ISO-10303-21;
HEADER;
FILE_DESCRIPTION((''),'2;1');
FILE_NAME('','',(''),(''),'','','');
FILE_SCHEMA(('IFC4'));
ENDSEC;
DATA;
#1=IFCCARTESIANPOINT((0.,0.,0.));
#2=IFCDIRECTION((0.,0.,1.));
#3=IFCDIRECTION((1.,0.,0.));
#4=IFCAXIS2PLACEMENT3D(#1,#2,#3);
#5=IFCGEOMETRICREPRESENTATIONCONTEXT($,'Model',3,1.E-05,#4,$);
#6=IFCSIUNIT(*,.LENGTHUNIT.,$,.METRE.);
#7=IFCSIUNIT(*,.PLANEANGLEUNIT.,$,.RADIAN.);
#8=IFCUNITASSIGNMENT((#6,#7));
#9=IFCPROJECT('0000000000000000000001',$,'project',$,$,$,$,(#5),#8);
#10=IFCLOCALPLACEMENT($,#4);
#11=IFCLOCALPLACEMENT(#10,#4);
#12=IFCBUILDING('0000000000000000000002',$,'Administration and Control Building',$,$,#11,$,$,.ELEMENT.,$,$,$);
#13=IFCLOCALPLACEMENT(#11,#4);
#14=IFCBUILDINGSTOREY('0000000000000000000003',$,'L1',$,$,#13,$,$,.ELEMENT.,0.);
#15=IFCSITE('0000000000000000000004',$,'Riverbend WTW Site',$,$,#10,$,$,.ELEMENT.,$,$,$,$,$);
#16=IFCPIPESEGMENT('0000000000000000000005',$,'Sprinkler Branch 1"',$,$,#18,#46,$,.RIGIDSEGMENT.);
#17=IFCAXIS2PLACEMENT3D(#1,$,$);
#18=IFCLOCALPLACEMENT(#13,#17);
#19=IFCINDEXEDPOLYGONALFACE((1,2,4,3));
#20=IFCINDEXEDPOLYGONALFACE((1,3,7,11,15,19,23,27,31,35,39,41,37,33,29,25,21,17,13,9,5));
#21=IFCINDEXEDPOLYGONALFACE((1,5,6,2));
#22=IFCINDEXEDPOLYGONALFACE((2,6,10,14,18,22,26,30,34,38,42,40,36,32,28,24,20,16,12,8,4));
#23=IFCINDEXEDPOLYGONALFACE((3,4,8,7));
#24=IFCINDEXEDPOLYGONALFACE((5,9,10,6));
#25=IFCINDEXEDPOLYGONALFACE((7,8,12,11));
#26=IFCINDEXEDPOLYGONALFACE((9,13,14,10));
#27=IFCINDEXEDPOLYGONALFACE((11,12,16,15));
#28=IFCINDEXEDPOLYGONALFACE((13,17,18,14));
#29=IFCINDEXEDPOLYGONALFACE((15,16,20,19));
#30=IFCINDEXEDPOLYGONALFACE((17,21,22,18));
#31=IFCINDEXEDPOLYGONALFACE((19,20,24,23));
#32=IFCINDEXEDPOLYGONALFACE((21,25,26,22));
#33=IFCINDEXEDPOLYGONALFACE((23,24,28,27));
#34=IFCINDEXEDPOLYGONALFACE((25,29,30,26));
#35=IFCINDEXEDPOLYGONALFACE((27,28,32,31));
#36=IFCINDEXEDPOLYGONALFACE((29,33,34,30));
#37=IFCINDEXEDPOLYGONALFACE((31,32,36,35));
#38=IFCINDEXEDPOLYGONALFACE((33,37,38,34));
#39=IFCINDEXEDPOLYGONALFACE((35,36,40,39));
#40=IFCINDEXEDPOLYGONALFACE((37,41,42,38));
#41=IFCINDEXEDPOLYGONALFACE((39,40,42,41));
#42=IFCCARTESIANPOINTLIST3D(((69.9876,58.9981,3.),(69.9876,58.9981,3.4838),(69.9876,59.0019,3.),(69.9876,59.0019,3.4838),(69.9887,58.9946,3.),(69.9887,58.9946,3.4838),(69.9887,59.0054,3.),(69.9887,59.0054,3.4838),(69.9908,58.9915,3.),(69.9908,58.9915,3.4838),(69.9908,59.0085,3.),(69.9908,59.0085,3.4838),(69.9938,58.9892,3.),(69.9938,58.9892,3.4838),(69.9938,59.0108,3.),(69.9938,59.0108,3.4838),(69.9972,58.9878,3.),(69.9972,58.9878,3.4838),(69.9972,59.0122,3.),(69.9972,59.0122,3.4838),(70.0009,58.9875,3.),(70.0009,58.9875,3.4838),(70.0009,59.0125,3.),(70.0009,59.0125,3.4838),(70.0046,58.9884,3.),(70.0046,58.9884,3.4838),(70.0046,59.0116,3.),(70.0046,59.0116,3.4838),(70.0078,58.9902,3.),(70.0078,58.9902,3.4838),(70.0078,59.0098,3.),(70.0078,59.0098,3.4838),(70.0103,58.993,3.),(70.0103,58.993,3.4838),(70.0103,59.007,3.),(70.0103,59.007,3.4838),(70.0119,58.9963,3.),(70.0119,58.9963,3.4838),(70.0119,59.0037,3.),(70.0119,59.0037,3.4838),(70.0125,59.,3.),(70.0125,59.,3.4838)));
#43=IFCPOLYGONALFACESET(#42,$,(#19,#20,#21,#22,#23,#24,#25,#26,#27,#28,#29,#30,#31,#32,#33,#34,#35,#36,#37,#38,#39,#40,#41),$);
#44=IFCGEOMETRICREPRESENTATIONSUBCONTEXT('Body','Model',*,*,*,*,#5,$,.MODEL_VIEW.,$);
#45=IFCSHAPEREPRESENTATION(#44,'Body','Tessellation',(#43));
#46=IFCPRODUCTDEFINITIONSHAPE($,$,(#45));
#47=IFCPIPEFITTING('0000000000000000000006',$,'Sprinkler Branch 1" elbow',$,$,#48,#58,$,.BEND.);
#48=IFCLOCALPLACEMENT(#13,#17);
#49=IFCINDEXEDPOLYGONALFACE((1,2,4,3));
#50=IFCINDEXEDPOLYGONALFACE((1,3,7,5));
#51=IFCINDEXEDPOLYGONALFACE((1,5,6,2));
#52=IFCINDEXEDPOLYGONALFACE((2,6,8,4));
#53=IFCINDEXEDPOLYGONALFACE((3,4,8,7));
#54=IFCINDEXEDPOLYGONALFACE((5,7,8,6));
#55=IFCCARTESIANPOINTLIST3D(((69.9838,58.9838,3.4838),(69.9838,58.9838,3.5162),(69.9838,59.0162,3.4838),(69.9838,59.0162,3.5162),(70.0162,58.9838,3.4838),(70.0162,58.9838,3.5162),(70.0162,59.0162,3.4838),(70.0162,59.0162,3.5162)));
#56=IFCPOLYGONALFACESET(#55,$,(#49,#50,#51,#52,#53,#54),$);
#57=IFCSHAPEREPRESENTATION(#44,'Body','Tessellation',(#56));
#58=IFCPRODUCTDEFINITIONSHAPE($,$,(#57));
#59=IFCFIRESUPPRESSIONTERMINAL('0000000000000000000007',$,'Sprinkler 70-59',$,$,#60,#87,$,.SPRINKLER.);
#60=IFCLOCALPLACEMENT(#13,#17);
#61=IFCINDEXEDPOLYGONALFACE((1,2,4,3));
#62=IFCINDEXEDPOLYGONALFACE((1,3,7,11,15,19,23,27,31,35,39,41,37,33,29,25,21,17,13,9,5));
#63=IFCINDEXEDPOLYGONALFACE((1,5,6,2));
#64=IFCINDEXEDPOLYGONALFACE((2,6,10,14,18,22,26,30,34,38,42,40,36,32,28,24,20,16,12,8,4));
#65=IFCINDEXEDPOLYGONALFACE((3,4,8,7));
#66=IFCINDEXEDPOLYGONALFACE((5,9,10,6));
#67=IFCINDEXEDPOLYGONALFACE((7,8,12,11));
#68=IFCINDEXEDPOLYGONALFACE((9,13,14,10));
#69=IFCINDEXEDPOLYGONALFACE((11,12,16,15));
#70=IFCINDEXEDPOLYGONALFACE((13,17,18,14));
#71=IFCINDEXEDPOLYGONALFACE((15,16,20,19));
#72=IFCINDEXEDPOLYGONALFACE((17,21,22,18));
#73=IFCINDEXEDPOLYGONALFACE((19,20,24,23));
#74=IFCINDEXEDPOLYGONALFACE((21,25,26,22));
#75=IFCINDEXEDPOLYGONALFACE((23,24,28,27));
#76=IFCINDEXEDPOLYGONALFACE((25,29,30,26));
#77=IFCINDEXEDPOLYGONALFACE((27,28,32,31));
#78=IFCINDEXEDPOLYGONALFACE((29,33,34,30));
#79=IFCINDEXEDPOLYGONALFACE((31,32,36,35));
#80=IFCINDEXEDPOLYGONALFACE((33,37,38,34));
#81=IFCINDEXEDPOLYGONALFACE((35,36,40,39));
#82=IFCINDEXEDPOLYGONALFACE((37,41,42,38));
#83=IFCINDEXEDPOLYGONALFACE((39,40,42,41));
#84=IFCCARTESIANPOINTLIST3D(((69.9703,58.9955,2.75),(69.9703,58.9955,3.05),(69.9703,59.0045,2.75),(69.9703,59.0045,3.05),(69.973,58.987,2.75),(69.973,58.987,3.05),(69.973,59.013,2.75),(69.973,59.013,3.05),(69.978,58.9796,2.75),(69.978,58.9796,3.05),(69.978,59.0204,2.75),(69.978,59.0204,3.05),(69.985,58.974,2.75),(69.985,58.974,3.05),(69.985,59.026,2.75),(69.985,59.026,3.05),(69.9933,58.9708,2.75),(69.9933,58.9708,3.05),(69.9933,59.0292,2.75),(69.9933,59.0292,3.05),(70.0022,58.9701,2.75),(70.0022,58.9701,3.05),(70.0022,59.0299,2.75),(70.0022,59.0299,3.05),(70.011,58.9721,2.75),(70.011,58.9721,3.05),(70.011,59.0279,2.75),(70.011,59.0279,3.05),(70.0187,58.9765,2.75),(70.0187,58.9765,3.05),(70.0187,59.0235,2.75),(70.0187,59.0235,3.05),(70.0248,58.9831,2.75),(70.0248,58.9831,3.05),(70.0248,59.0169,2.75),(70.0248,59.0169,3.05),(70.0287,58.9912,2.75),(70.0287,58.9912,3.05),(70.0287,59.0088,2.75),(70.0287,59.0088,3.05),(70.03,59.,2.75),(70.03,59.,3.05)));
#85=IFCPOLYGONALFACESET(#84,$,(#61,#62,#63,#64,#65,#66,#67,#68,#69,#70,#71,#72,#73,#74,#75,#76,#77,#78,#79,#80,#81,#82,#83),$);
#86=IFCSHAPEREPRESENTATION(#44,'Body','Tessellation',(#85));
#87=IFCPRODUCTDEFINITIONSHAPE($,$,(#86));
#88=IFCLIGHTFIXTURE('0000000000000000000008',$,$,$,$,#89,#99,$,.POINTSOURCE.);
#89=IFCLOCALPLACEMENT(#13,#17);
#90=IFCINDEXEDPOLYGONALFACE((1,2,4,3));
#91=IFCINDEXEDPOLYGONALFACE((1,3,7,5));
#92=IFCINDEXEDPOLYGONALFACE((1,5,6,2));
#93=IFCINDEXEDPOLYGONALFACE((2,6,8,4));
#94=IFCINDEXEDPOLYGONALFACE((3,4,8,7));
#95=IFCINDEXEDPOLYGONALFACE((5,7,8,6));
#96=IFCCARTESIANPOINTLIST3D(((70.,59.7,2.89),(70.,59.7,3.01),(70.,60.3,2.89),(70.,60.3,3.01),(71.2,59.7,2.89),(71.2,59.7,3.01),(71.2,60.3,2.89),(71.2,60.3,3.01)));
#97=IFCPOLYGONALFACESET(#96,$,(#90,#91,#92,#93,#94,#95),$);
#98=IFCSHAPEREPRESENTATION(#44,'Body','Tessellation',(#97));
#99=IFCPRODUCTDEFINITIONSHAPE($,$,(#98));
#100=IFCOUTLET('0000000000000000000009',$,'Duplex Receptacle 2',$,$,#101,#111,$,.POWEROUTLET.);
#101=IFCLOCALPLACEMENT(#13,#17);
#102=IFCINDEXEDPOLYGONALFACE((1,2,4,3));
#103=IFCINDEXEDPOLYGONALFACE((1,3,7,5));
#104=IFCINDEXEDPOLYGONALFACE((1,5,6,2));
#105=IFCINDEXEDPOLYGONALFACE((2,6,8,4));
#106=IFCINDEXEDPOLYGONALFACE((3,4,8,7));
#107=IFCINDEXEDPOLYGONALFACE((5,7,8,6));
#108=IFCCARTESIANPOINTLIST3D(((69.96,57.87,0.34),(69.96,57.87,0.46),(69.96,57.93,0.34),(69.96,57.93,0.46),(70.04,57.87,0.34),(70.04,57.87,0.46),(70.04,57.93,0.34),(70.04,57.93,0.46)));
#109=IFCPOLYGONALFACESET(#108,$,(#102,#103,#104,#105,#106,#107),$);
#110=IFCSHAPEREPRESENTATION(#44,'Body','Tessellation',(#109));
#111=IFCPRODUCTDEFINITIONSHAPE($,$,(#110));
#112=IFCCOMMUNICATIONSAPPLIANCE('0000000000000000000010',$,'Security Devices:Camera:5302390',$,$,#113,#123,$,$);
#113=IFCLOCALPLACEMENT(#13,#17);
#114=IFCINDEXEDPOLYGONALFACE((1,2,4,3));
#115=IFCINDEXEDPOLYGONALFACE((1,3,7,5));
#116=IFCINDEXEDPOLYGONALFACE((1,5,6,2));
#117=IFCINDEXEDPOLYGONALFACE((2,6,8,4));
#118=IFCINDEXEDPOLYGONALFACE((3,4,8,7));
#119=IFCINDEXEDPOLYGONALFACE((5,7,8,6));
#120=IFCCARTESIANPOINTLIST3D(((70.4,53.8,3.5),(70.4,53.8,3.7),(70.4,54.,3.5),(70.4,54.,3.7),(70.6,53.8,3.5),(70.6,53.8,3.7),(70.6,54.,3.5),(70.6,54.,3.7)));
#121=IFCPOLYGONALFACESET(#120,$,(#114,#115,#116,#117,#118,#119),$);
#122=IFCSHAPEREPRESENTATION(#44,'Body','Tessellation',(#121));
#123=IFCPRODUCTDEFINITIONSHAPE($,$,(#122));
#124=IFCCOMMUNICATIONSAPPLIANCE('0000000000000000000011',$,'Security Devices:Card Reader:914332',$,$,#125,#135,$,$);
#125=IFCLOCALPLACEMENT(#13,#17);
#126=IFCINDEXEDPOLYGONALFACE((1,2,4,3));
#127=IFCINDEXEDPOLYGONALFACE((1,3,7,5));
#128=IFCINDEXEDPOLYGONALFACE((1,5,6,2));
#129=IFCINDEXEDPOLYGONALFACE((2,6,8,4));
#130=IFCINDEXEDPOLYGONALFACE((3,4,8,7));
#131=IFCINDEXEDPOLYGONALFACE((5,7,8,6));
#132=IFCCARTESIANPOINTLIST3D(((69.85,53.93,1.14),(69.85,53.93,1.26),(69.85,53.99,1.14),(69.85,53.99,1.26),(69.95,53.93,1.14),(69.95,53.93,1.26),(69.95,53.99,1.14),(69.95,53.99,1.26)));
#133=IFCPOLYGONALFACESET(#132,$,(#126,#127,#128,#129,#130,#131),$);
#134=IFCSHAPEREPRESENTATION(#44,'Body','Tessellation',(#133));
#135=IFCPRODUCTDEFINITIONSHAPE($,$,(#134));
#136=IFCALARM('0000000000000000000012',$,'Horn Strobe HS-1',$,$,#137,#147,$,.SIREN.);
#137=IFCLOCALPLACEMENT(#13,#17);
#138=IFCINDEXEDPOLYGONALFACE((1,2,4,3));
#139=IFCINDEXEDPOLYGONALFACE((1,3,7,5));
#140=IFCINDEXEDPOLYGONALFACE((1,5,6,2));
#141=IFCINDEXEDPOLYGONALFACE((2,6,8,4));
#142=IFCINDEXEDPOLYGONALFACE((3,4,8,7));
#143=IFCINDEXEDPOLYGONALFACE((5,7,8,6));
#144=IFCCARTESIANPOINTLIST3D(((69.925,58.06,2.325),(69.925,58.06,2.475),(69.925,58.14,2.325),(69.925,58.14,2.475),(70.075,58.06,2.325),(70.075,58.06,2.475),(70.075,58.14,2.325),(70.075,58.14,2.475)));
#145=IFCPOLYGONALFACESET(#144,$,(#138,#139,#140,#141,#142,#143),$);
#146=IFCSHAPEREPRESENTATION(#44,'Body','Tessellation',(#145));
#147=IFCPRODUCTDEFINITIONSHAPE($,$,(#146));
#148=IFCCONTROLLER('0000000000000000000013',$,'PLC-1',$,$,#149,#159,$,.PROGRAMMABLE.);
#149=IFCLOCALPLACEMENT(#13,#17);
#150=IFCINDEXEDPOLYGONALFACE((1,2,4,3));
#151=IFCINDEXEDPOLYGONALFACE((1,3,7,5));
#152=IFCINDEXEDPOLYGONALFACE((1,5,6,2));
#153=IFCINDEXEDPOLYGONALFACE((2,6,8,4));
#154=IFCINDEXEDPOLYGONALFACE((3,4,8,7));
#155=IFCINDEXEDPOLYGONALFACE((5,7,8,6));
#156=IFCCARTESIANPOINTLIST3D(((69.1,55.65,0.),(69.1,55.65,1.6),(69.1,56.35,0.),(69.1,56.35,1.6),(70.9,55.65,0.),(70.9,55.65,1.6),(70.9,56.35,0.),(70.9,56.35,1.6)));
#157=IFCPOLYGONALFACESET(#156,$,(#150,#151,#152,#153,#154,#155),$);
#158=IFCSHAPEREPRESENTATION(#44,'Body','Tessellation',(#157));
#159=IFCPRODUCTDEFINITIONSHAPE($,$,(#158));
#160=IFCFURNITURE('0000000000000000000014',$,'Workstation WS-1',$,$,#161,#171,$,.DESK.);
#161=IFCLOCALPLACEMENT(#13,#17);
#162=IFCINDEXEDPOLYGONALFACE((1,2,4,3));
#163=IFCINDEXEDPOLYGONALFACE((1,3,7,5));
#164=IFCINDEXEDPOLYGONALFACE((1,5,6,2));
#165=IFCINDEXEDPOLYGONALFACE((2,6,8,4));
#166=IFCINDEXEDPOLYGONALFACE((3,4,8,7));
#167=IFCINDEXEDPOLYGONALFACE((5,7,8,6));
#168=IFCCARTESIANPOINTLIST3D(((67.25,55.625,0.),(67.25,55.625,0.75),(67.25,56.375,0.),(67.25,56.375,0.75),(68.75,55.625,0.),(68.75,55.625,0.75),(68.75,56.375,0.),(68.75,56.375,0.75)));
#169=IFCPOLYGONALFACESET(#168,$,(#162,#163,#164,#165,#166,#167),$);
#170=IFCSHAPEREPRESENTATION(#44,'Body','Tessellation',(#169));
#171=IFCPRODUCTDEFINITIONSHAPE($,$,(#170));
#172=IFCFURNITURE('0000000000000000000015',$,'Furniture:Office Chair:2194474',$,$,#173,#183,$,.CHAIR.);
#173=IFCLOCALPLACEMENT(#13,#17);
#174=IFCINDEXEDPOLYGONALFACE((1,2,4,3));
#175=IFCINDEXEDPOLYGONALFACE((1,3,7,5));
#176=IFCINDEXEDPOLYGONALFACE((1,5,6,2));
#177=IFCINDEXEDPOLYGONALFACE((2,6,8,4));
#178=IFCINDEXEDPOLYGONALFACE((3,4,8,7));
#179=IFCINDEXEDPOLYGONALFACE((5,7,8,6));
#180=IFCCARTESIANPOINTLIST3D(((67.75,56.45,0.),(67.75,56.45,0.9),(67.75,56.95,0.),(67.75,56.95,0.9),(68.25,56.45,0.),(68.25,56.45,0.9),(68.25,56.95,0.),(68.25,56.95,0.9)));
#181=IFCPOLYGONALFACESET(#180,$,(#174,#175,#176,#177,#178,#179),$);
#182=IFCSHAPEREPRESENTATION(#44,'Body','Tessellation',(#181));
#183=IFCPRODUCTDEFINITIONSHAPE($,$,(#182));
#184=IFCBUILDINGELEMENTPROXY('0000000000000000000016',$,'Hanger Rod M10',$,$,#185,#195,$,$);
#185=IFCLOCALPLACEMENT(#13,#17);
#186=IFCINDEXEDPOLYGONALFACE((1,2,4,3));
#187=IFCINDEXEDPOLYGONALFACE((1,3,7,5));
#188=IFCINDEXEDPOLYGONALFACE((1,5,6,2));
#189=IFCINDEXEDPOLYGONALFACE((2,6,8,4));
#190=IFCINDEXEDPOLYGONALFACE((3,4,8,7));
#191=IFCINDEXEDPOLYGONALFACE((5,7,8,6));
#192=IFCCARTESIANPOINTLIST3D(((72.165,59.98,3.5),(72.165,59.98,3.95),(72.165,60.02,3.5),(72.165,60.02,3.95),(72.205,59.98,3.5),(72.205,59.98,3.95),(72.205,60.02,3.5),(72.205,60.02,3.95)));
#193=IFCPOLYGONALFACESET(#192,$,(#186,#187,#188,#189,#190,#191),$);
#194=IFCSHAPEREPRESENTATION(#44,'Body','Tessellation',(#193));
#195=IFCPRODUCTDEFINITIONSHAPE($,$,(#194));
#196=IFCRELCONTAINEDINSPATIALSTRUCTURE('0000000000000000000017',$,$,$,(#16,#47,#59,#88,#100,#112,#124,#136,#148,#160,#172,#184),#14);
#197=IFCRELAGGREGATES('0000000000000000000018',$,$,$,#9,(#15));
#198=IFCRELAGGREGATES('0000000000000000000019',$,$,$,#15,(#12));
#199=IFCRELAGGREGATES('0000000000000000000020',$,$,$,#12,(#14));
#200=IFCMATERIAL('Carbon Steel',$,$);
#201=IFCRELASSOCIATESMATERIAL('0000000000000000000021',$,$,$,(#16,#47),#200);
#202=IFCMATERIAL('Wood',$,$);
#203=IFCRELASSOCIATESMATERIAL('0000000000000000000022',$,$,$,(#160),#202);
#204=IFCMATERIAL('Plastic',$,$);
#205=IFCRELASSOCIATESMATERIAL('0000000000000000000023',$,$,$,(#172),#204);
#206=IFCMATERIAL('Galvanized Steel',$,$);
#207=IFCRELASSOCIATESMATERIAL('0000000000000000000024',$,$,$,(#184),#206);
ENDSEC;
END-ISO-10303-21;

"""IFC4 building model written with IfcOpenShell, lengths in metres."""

from ifc_helpers import new_model, si_unit, frame, origin_with_axes, origin_2d, place, context, subcontext, project, spatial, rectangle, circle, extrude, material, element, save


model = new_model("IFC4")

# Units and contexts
model_context = context("Model", 3, precision=1e-05, world=origin_with_axes())
body_context = subcontext(model_context, "Body", "Model", "MODEL_VIEW")
ifc_project = project(units=[si_unit("LENGTHUNIT", "METRE"), si_unit("PLANEANGLEUNIT", "RADIAN")], contexts=[model_context])

# Site, building, storey
site_placement = place(None, origin_with_axes())
site = spatial("IfcSite", under=ifc_project, at=site_placement, Name="Riverbend WTW Site", CompositionType="ELEMENT")
building_placement = place(site_placement, origin_with_axes())
building = spatial("IfcBuilding", under=site, at=building_placement, Name="Administration and Control Building", CompositionType="ELEMENT")
storey_placement = place(building_placement, origin_with_axes())
storey = spatial("IfcBuildingStorey", under=building, at=storey_placement, Name="L1", CompositionType="ELEMENT", Elevation=0.0)

# Shared definitions
ifc_material_1 = material(Name="Galvanized Steel")

# Pipe segment
ifc_material_2 = material(Name="Carbon Steel")
pipe_segment_placement = place(None, frame((70.0, 59.0, 3.4838), z_axis=(0.0, 0.0, 1.0), x_axis=(1.0, 0.0, 0.0)))
element("IfcPipeSegment", 1, at=pipe_segment_placement, inside=storey, material=ifc_material_2, Name="Sprinkler Branch 1\"", PredefinedType="RIGIDSEGMENT", context=body_context, shape_type="SweptSolid", body=[
    extrude(circle(Radius=0.0125, at=origin_2d()), frame((0.0, 0.0, 0.0), z_axis=(0.0, 0.0, -1.0), x_axis=(1.0, 0.0, 0.0)), (0.0, 0.0, 1.0), 0.4838),
])

# Pipe fitting
pipe_fitting_placement = place(None, frame((70.0, 59.0, 3.5), z_axis=(0.0, 0.0, 1.0), x_axis=(1.0, 0.0, 0.0)))
element("IfcPipeFitting", 2, at=pipe_fitting_placement, inside=storey, material=ifc_material_2, Name="Sprinkler Branch 1\" elbow", PredefinedType="BEND", context=body_context, shape_type="SweptSolid", body=[
    extrude(rectangle(XDim=0.0325, YDim=0.0325, at=origin_2d()), frame((0.0, 0.0, -0.0162), z_axis=(0.0, 0.0, 1.0), x_axis=(1.0, 0.0, 0.0)), (0.0, 0.0, 1.0), 0.0325),
])

# Fire suppression terminal
fire_suppression_terminal_placement = place(None, frame((70.0, 59.0, 2.75), z_axis=(0.0, 0.0, 1.0), x_axis=(1.0, 0.0, 0.0)))
element("IfcFireSuppressionTerminal", 3, at=fire_suppression_terminal_placement, inside=storey, Name="Sprinkler 70-59", PredefinedType="SPRINKLER", context=body_context, shape_type="SweptSolid", body=[
    extrude(circle(Radius=0.03, at=origin_2d()), origin_with_axes(), (0.0, 0.0, 1.0), 0.3),
])

# Light fixture
light_fixture_placement = place(None, frame((70.6, 60.0, 2.95), z_axis=(0.0, 0.0, 1.0), x_axis=(1.0, 0.0, 0.0)))
element("IfcLightFixture", 4, at=light_fixture_placement, inside=storey, PredefinedType="POINTSOURCE", context=body_context, shape_type="SweptSolid", body=[
    extrude(rectangle(XDim=1.2, YDim=0.6, at=origin_2d()), frame((0.0, 0.0, -0.06), z_axis=(0.0, 0.0, 1.0), x_axis=(1.0, 0.0, 0.0)), (0.0, 0.0, 1.0), 0.12),
])

# Outlet
outlet_placement = place(None, frame((70.0, 57.9, 0.4), z_axis=(0.0, 0.0, 1.0), x_axis=(1.0, 0.0, 0.0)))
element("IfcOutlet", 5, at=outlet_placement, inside=storey, Name="Duplex Receptacle 2", PredefinedType="POWEROUTLET", context=body_context, shape_type="SweptSolid", body=[
    extrude(rectangle(XDim=0.08, YDim=0.06, at=origin_2d()), frame((0.0, 0.0, -0.06), z_axis=(0.0, 0.0, 1.0), x_axis=(1.0, 0.0, 0.0)), (0.0, 0.0, 1.0), 0.12),
])

# Communications appliances
communications_appliance_1_placement = place(None, frame((70.5, 53.9, 3.6), z_axis=(0.0, 0.0, 1.0), x_axis=(1.0, 0.0, 0.0)))
element("IfcCommunicationsAppliance", 6, at=communications_appliance_1_placement, inside=storey, Name="Security Devices:Camera:5302390", context=body_context, shape_type="SweptSolid", body=[
    extrude(rectangle(XDim=0.2, YDim=0.2, at=origin_2d()), frame((0.0, 0.0, -0.1), z_axis=(0.0, 0.0, 1.0), x_axis=(1.0, 0.0, 0.0)), (0.0, 0.0, 1.0), 0.2),
])
communications_appliance_2_placement = place(None, frame((69.9, 53.96, 1.2), z_axis=(0.0, 0.0, 1.0), x_axis=(1.0, 0.0, 0.0)))
element("IfcCommunicationsAppliance", 7, at=communications_appliance_2_placement, inside=storey, Name="Security Devices:Card Reader:914332", context=body_context, shape_type="SweptSolid", body=[
    extrude(rectangle(XDim=0.1, YDim=0.06, at=origin_2d()), frame((0.0, 0.0, -0.06), z_axis=(0.0, 0.0, 1.0), x_axis=(1.0, 0.0, 0.0)), (0.0, 0.0, 1.0), 0.12),
])

# Alarm
alarm_placement = place(None, frame((70.0, 58.1, 2.4), z_axis=(0.0, 0.0, 1.0), x_axis=(1.0, 0.0, 0.0)))
element("IfcAlarm", 8, at=alarm_placement, inside=storey, Name="Horn Strobe HS-1", PredefinedType="SIREN", context=body_context, shape_type="SweptSolid", body=[
    extrude(rectangle(XDim=0.15, YDim=0.08, at=origin_2d()), frame((0.0, 0.0, -0.075), z_axis=(0.0, 0.0, 1.0), x_axis=(1.0, 0.0, 0.0)), (0.0, 0.0, 1.0), 0.15),
])

# Controller
controller_placement = place(None, frame((70.0, 56.0, 0.8), z_axis=(0.0, 0.0, 1.0), x_axis=(1.0, 0.0, 0.0)))
element("IfcController", 9, at=controller_placement, inside=storey, Name="PLC-1", PredefinedType="PROGRAMMABLE", context=body_context, shape_type="SweptSolid", body=[
    extrude(rectangle(XDim=1.8, YDim=0.7, at=origin_2d()), frame((0.0, 0.0, -0.8), z_axis=(0.0, 0.0, 1.0), x_axis=(1.0, 0.0, 0.0)), (0.0, 0.0, 1.0), 1.6),
])

# Furniture
ifc_material_3 = material(Name="Wood")
furniture_1_placement = place(None, frame((68.0, 56.0, 0.375), z_axis=(0.0, 0.0, 1.0), x_axis=(1.0, 0.0, 0.0)))
element("IfcFurniture", 10, at=furniture_1_placement, inside=storey, material=ifc_material_3, Name="Workstation WS-1", PredefinedType="DESK", context=body_context, shape_type="SweptSolid", body=[
    extrude(rectangle(XDim=1.5, YDim=0.75, at=origin_2d()), frame((0.0, 0.0, -0.375), z_axis=(0.0, 0.0, 1.0), x_axis=(1.0, 0.0, 0.0)), (0.0, 0.0, 1.0), 0.75),
])
ifc_material_4 = material(Name="Plastic")
furniture_2_placement = place(None, frame((68.0, 56.7, 0.45), z_axis=(0.0, 0.0, 1.0), x_axis=(1.0, 0.0, 0.0)))
element("IfcFurniture", 11, at=furniture_2_placement, inside=storey, material=ifc_material_4, Name="Furniture:Office Chair:2194474", PredefinedType="CHAIR", context=body_context, shape_type="SweptSolid", body=[
    extrude(rectangle(XDim=0.5, YDim=0.5, at=origin_2d()), frame((0.0, 0.0, -0.45), z_axis=(0.0, 0.0, 1.0), x_axis=(1.0, 0.0, 0.0)), (0.0, 0.0, 1.0), 0.9),
])

# Building element proxy
proxy_1_placement = place(None, frame((72.185, 60.0, 3.725), z_axis=(0.0, 0.0, 1.0), x_axis=(1.0, 0.0, 0.0)))
element("IfcBuildingElementProxy", 12, at=proxy_1_placement, inside=storey, material=ifc_material_1, Name="Hanger Rod M10", context=body_context, shape_type="SweptSolid", body=[
    extrude(rectangle(XDim=0.04, YDim=0.04, at=origin_2d()), frame((0.0, 0.0, -0.225), z_axis=(0.0, 0.0, 1.0), x_axis=(1.0, 0.0, 0.0)), (0.0, 0.0, 1.0), 0.45),
])

save(model, "model.ifc")
